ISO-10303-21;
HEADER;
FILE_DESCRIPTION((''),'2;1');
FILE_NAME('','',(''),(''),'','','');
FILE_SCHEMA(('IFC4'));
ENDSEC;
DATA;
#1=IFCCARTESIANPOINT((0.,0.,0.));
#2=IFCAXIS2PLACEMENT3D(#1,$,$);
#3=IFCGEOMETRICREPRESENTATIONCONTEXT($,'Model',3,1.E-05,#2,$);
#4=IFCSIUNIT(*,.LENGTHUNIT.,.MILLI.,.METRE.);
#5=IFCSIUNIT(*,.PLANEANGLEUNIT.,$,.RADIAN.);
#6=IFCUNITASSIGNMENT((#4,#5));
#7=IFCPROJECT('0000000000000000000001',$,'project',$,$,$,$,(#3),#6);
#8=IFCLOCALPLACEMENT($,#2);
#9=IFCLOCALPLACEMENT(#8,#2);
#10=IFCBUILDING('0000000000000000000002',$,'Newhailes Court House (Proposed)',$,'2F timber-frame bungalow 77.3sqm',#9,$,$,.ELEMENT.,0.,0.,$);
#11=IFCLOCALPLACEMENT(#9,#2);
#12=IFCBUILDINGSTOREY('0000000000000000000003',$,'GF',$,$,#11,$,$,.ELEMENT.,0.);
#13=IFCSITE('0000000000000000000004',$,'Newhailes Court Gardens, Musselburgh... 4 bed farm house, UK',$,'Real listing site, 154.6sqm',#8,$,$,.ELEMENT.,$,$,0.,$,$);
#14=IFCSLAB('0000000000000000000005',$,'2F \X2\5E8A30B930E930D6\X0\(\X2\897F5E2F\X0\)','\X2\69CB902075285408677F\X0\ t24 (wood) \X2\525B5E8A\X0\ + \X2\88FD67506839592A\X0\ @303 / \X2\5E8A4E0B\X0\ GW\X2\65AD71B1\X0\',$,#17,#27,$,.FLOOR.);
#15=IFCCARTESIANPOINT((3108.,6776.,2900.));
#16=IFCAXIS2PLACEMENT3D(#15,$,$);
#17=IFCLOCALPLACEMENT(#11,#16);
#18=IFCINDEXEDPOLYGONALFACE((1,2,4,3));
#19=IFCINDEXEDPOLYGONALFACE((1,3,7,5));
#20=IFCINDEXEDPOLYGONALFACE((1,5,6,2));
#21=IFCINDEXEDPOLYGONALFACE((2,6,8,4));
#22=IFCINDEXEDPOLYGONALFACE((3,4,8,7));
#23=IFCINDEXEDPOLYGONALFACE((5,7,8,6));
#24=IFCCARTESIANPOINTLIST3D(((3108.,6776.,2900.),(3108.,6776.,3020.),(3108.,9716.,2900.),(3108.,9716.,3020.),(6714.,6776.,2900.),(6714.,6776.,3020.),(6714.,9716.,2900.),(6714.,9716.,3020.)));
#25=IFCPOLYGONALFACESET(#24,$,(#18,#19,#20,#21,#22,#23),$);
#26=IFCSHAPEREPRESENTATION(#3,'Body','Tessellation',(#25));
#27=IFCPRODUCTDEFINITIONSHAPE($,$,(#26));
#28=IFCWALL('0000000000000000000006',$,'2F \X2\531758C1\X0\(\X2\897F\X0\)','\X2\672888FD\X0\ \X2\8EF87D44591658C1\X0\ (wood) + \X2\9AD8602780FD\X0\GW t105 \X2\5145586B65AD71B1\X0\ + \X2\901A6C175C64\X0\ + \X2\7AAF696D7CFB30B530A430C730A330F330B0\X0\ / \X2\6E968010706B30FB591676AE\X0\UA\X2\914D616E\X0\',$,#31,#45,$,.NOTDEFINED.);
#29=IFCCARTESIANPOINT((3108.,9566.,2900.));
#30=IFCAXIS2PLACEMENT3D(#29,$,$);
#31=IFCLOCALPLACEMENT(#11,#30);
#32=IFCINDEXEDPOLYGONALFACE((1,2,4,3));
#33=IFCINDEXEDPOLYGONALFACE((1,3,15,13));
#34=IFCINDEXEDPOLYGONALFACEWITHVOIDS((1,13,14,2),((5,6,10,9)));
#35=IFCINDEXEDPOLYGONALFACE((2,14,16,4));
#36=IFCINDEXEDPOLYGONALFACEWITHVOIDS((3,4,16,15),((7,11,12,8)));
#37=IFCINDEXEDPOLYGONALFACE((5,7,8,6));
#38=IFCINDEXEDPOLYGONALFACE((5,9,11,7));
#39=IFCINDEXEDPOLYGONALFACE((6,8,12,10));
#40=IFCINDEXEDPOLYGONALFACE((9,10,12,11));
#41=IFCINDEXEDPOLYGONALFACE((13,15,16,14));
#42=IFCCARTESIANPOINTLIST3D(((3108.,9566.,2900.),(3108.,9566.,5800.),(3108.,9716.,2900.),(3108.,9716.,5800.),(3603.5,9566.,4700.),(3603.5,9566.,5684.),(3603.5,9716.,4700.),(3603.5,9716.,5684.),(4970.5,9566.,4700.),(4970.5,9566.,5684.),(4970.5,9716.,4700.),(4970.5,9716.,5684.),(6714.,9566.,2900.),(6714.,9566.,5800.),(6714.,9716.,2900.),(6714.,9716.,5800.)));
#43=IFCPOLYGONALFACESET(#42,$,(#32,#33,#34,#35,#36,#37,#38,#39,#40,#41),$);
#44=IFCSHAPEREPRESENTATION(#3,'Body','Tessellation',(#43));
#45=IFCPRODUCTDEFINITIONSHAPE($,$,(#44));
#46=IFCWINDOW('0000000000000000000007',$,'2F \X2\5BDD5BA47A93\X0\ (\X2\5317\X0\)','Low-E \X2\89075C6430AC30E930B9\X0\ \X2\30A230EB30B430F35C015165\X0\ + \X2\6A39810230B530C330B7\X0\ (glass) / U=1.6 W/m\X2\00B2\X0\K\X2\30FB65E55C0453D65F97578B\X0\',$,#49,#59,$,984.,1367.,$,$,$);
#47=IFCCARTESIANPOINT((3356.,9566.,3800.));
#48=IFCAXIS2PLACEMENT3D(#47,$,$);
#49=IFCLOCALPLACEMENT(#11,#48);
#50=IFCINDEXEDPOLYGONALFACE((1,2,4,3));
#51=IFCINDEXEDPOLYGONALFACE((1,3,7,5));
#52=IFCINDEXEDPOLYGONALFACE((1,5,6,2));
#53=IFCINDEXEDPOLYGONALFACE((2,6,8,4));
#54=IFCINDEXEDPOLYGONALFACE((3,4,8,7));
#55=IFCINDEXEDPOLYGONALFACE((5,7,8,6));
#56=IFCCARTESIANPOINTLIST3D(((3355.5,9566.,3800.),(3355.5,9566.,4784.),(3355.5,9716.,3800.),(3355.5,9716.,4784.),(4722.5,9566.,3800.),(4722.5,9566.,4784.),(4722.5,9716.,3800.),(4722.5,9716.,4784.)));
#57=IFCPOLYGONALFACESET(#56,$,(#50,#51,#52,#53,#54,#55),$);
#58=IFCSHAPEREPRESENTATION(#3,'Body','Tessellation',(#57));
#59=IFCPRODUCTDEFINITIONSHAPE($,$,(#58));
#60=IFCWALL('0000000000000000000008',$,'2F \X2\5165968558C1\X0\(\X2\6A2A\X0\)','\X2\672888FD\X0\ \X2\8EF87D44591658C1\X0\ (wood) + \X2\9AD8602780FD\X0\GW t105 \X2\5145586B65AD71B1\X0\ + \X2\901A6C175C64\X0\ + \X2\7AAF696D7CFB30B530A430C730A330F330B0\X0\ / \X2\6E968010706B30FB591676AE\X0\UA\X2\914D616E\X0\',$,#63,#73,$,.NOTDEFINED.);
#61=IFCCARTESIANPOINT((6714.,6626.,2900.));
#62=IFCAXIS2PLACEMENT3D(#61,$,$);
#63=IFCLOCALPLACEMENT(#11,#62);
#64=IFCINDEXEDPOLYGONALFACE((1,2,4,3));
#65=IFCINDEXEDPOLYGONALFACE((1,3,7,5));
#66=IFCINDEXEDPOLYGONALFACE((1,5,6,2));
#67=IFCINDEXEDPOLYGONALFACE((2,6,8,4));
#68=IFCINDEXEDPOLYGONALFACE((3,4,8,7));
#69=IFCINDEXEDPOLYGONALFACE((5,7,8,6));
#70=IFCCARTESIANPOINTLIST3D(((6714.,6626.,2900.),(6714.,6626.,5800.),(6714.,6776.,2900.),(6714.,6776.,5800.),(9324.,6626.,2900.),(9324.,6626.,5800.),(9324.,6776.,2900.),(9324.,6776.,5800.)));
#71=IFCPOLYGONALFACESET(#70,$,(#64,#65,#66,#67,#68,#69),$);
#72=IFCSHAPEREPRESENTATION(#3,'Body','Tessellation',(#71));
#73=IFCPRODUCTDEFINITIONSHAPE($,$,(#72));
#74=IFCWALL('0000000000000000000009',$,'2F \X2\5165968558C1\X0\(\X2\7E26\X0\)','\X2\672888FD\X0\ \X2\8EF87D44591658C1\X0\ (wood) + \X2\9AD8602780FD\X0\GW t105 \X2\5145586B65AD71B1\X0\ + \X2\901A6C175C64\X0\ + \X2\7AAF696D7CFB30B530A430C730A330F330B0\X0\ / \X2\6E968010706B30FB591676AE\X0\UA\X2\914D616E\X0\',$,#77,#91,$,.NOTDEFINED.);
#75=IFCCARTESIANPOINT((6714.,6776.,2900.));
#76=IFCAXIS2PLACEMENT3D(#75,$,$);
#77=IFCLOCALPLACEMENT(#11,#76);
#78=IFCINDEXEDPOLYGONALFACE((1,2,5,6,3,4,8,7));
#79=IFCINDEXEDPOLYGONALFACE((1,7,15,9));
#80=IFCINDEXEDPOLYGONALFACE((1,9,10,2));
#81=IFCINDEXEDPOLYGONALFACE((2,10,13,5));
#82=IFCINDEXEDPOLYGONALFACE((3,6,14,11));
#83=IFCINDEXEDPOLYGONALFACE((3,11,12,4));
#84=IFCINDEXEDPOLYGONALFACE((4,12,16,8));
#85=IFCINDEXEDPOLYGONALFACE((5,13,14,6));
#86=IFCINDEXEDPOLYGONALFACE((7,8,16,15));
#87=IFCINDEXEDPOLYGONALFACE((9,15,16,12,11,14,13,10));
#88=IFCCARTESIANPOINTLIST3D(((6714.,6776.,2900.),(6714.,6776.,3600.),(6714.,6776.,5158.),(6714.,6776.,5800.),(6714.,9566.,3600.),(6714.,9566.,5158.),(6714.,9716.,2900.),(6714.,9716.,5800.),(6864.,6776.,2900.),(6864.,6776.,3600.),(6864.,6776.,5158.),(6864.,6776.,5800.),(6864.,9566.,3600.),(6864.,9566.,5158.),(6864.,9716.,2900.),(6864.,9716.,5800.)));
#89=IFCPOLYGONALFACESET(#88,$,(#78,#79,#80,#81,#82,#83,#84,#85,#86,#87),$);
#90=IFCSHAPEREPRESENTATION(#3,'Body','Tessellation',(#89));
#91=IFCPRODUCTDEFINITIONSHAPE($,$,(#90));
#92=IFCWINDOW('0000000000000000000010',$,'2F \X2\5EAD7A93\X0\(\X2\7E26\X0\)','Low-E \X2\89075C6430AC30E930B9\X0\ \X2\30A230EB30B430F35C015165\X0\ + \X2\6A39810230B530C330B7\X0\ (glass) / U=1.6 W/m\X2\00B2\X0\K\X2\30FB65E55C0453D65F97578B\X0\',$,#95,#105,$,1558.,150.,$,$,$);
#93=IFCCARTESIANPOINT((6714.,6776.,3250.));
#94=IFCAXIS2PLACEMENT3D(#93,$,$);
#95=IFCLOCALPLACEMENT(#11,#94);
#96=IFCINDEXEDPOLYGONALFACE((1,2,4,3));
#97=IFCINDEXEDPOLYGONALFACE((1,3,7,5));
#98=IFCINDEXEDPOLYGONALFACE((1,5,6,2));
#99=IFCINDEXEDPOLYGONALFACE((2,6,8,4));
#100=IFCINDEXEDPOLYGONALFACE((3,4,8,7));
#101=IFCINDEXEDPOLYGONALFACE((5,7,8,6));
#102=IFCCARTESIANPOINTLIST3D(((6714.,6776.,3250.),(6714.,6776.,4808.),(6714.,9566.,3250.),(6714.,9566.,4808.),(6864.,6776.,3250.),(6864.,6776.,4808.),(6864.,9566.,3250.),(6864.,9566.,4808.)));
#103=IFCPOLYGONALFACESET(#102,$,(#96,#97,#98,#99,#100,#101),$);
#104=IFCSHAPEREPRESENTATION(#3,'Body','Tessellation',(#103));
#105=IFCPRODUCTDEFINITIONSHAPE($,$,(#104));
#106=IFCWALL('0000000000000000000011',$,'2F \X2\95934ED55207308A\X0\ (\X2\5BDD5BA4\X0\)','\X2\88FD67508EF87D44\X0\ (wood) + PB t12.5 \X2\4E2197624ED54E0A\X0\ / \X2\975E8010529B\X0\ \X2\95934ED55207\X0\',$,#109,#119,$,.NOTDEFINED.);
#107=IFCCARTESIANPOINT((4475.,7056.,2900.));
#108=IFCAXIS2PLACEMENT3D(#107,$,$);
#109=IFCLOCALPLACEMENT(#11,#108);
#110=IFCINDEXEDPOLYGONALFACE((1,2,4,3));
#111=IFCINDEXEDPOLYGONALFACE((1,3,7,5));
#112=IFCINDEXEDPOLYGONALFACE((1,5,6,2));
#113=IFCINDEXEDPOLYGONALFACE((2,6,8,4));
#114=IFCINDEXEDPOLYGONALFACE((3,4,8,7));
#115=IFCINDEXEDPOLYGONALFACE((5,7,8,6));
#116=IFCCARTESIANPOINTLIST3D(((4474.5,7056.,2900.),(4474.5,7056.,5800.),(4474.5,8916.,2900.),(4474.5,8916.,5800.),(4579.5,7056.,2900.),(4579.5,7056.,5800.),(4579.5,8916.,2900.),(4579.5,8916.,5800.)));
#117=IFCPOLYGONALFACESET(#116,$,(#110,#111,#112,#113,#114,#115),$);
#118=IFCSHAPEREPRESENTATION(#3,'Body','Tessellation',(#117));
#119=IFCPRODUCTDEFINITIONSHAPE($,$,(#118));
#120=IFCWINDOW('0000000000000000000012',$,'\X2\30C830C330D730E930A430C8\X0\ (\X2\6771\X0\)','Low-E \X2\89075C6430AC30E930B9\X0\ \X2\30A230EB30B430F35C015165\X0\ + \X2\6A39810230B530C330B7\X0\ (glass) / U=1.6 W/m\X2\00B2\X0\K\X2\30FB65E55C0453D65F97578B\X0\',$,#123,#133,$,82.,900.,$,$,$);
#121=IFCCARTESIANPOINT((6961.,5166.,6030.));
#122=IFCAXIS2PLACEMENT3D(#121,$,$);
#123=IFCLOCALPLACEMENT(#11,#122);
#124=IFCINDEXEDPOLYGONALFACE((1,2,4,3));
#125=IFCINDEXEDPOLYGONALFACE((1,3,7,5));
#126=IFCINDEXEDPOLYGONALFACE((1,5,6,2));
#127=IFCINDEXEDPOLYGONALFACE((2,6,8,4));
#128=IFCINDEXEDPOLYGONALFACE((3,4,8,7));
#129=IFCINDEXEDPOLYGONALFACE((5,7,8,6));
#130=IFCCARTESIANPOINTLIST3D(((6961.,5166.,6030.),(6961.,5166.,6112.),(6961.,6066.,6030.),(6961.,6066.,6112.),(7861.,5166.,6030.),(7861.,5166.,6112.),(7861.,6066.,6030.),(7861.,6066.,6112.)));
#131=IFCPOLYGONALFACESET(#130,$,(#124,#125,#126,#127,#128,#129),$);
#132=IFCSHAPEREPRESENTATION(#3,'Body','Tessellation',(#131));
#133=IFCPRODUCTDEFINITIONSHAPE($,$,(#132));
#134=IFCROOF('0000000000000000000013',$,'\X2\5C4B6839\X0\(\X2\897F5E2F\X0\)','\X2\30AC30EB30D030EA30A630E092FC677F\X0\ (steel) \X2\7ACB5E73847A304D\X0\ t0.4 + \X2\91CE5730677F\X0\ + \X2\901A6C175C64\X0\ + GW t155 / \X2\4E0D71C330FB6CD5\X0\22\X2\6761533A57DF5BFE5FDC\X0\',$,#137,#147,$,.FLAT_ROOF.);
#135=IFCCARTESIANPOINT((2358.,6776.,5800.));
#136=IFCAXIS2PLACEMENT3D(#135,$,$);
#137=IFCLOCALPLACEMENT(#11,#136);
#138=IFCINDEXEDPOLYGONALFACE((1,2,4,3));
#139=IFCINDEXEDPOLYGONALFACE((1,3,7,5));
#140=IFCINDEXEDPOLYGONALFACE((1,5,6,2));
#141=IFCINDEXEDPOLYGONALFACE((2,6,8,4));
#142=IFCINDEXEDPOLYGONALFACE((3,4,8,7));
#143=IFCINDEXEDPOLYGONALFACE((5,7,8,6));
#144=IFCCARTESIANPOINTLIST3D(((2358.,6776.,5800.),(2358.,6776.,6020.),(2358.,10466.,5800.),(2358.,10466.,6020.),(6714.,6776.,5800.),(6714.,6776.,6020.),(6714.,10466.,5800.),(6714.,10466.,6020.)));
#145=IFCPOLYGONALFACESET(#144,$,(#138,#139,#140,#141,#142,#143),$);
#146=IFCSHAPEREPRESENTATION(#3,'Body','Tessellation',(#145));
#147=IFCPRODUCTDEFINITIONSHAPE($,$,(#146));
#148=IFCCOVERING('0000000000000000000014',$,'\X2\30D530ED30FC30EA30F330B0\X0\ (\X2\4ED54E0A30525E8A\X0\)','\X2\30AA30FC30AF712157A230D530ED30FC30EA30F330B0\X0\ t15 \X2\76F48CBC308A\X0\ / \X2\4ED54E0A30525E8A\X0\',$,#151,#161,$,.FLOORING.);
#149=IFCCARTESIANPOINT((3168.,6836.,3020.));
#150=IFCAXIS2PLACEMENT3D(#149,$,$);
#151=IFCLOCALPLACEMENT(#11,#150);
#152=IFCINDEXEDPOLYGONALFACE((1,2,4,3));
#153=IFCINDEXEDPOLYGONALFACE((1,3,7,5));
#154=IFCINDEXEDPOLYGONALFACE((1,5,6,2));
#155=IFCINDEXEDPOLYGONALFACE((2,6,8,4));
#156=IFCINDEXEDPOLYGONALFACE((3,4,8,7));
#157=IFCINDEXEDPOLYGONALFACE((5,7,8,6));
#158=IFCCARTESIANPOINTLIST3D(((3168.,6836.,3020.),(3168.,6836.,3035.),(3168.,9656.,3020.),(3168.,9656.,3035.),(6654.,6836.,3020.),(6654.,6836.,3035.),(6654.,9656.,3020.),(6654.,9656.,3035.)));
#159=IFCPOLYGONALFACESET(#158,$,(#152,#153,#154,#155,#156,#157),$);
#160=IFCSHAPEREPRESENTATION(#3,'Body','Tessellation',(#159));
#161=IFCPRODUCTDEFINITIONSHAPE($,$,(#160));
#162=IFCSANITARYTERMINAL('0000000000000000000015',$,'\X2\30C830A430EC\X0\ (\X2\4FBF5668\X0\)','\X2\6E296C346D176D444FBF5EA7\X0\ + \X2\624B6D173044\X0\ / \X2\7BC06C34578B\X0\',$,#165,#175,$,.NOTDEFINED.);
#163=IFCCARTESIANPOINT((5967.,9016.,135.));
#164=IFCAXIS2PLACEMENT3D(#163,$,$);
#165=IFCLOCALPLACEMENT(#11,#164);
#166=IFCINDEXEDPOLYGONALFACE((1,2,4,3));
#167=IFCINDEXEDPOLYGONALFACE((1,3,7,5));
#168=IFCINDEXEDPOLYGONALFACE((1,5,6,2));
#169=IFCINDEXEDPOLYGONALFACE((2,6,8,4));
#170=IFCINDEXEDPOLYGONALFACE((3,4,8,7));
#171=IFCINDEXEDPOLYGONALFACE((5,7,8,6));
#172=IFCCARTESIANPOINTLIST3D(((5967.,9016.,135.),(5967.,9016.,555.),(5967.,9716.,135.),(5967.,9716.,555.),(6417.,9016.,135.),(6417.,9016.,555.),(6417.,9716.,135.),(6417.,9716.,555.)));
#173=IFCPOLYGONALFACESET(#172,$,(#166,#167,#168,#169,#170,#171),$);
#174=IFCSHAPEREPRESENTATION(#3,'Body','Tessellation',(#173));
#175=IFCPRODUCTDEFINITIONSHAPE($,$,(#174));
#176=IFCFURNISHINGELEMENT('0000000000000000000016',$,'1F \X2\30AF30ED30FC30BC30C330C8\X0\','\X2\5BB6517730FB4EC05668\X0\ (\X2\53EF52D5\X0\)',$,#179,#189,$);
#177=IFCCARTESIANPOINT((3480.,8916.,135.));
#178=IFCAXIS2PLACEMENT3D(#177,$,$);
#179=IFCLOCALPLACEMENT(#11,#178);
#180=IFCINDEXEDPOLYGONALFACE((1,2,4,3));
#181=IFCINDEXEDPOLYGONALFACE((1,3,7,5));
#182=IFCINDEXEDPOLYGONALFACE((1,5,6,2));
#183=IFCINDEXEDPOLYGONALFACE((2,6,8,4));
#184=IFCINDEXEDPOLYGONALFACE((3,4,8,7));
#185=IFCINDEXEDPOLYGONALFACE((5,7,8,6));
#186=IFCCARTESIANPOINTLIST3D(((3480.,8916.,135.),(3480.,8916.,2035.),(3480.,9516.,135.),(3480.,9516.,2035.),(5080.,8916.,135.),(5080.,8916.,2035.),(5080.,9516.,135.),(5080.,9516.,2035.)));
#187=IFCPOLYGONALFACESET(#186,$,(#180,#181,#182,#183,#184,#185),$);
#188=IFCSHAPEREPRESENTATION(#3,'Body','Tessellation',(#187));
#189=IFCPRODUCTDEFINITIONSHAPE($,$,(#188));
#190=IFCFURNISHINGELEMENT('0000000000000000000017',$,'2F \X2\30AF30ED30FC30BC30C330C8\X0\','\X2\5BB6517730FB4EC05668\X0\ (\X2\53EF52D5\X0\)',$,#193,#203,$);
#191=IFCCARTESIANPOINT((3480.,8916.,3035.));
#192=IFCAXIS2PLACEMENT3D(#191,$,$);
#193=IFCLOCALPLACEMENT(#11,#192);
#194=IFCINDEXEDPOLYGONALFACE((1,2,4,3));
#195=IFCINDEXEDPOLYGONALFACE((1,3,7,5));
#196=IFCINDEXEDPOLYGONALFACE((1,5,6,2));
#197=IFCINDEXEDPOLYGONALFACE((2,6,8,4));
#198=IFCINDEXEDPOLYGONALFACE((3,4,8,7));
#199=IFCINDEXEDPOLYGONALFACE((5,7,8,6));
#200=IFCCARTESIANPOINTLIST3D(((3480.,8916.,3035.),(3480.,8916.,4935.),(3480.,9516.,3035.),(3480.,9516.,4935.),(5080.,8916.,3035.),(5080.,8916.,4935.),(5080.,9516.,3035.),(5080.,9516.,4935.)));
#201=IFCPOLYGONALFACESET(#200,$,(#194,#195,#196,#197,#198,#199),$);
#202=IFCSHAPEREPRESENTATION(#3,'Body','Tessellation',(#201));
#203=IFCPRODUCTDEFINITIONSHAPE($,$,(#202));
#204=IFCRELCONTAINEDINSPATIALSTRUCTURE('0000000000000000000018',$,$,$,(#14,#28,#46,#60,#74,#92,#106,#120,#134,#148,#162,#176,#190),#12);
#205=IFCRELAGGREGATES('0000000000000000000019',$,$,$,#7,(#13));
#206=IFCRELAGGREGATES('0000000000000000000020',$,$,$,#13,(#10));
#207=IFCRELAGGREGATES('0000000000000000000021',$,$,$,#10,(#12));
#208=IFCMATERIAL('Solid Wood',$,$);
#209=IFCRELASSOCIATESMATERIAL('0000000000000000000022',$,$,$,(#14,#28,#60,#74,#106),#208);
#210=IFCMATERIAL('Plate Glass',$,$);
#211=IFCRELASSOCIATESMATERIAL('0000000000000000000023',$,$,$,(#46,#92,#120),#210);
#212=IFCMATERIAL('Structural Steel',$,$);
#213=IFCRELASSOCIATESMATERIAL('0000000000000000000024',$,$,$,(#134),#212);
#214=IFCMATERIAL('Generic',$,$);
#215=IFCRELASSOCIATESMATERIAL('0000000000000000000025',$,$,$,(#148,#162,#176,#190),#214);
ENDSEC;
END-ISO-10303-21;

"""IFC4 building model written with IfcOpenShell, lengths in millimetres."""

from ifc_helpers import new_model, si_unit, frame, frame_2d, origin, place, context, project, spatial, rectangle, extrude, material, element, fill, save


model = new_model("IFC4")

# Units and contexts
model_context = context("Model", 3, precision=1e-05, world=origin())
ifc_project = project(units=[si_unit("LENGTHUNIT", "METRE", prefix="MILLI"), si_unit("PLANEANGLEUNIT", "RADIAN")], contexts=[model_context])

# Site, building, storey
site_placement = place(None, origin())
site = spatial("IfcSite", under=ifc_project, at=site_placement, Name="Newhailes Court Gardens, Musselburgh... 4 bed farm house, UK", ObjectType="Real listing site, 154.6sqm", CompositionType="ELEMENT", RefElevation=0.0)
building_placement = place(site_placement, origin())
building = spatial("IfcBuilding", under=site, at=building_placement, Name="Newhailes Court House (Proposed)", ObjectType="2F timber-frame bungalow 77.3sqm", CompositionType="ELEMENT", ElevationOfRefHeight=0.0, ElevationOfTerrain=0.0)
storey_placement = place(building_placement, origin())
storey = spatial("IfcBuildingStorey", under=building, at=storey_placement, Name="GF", CompositionType="ELEMENT", Elevation=0.0)

# Slab
ifc_material_1 = material(Name="Solid Wood")
slab_placement = place(storey_placement, frame((3108.0, 6776.0, 2900.0)))
element("IfcSlab", 1, at=slab_placement, inside=storey, material=ifc_material_1, Name="2F 床スラブ(西帯)", Description="構造用合板 t24 (wood) 剛床 + 製材根太 @303 / 床下 GW断熱", PredefinedType="FLOOR", context=model_context, shape_type="SweptSolid", body=[
    extrude(rectangle(XDim=3606.0, YDim=2940.0, at=frame_2d((1803.0, 1470.0))), frame((3108.0, 6776.0, 2900.0)), (0.0, 0.0, 1.0), 120.0),
])

# Wall, opening, window
wall_1_placement = place(storey_placement, frame((3108.0, 9566.0, 2900.0)))
wall_1 = element("IfcWall", 2, at=wall_1_placement, inside=storey, material=ifc_material_1, Name="2F 北壁(西)", Description="木製 軸組外壁 (wood) + 高性能GW t105 充填断熱 + 通気層 + 窯業系サイディング / 準耐火・外皮UA配慮", PredefinedType="NOTDEFINED", context=model_context, shape_type="SweptSolid", body=[
    extrude(rectangle(XDim=3606.0, YDim=150.0, at=frame_2d((1803.0, 75.0))), frame((3108.0, 9566.0, 2900.0)), (0.0, 0.0, 1.0), 2900.0),
])
opening_1_placement = place(storey_placement, frame((3356.0, 9566.0, 3800.0)))
opening_1 = element("IfcOpeningElement", 3, at=opening_1_placement, cuts=wall_1, PredefinedType="NOTDEFINED", context=model_context, shape_type="SweptSolid", body=[
    extrude(rectangle(XDim=1367.0, YDim=150.0, at=frame_2d((683.0, 75.0))), frame((3356.0, 9566.0, 3800.0)), (0.0, 0.0, 1.0), 984.0),
])
ifc_material_2 = material(Name="Plate Glass")
window_1_placement = place(storey_placement, frame((3356.0, 9566.0, 3800.0)))
window_1 = element("IfcWindow", 4, at=window_1_placement, inside=storey, material=ifc_material_2, Name="2F 寝室窓 (北)", Description="Low-E 複層ガラス アルゴン封入 + 樹脂サッシ (glass) / U=1.6 W/m²K・日射取得型", OverallHeight=984.0, OverallWidth=1367.0, context=model_context, shape_type="SweptSolid", body=[
    extrude(rectangle(XDim=1367.0, YDim=150.0, at=frame_2d((683.0, 75.0))), frame((3356.0, 9566.0, 3800.0)), (0.0, 0.0, 1.0), 984.0),
])
fill(opening_1, window_1)

# Wall
wall_2_placement = place(storey_placement, frame((6714.0, 6626.0, 2900.0)))
element("IfcWall", 5, at=wall_2_placement, inside=storey, material=ifc_material_1, Name="2F 入隅壁(横)", Description="木製 軸組外壁 (wood) + 高性能GW t105 充填断熱 + 通気層 + 窯業系サイディング / 準耐火・外皮UA配慮", PredefinedType="NOTDEFINED", context=model_context, shape_type="SweptSolid", body=[
    extrude(rectangle(XDim=2610.0, YDim=150.0, at=frame_2d((1305.0, 75.0))), frame((6714.0, 6626.0, 2900.0)), (0.0, 0.0, 1.0), 2900.0),
])

# Wall, opening, window
wall_3_placement = place(storey_placement, frame((6714.0, 6776.0, 2900.0)))
wall_3 = element("IfcWall", 6, at=wall_3_placement, inside=storey, material=ifc_material_1, Name="2F 入隅壁(縦)", Description="木製 軸組外壁 (wood) + 高性能GW t105 充填断熱 + 通気層 + 窯業系サイディング / 準耐火・外皮UA配慮", PredefinedType="NOTDEFINED", context=model_context, shape_type="SweptSolid", body=[
    extrude(rectangle(XDim=150.0, YDim=2940.0, at=frame_2d((75.0, 1470.0))), frame((6714.0, 6776.0, 2900.0)), (0.0, 0.0, 1.0), 2900.0),
])
opening_2_placement = place(storey_placement, frame((6714.0, 6776.0, 3250.0)))
opening_2 = element("IfcOpeningElement", 7, at=opening_2_placement, cuts=wall_3, PredefinedType="NOTDEFINED", context=model_context, shape_type="SweptSolid", body=[
    extrude(rectangle(XDim=150.0, YDim=2790.0, at=frame_2d((75.0, 1395.0))), frame((6714.0, 6776.0, 3250.0)), (0.0, 0.0, 1.0), 1558.0),
])
window_2_placement = place(storey_placement, frame((6714.0, 6776.0, 3250.0)))
window_2 = element("IfcWindow", 8, at=window_2_placement, inside=storey, material=ifc_material_2, Name="2F 庭窓(縦)", Description="Low-E 複層ガラス アルゴン封入 + 樹脂サッシ (glass) / U=1.6 W/m²K・日射取得型", OverallHeight=1558.0, OverallWidth=150.0, context=model_context, shape_type="SweptSolid", body=[
    extrude(rectangle(XDim=150.0, YDim=2790.0, at=frame_2d((75.0, 1395.0))), frame((6714.0, 6776.0, 3250.0)), (0.0, 0.0, 1.0), 1558.0),
])
fill(opening_2, window_2)

# Wall
wall_4_placement = place(storey_placement, frame((4475.0, 7056.0, 2900.0)))
element("IfcWall", 9, at=wall_4_placement, inside=storey, material=ifc_material_1, Name="2F 間仕切り (寝室)", Description="製材軸組 (wood) + PB t12.5 両面仕上 / 非耐力 間仕切", PredefinedType="NOTDEFINED", context=model_context, shape_type="SweptSolid", body=[
    extrude(rectangle(XDim=105.0, YDim=1860.0, at=frame_2d((52.0, 930.0))), frame((4475.0, 7056.0, 2900.0)), (0.0, 0.0, 1.0), 2900.0),
])

# Window
window_3_placement = place(storey_placement, frame((6961.0, 5166.0, 6030.0)))
element("IfcWindow", 10, at=window_3_placement, inside=storey, material=ifc_material_2, Name="トップライト (東)", Description="Low-E 複層ガラス アルゴン封入 + 樹脂サッシ (glass) / U=1.6 W/m²K・日射取得型", OverallHeight=82.0, OverallWidth=900.0, context=model_context, shape_type="SweptSolid", body=[
    extrude(rectangle(XDim=900.0, YDim=900.0, at=frame_2d((450.0, 450.0))), frame((6961.0, 5166.0, 6030.0)), (0.0, 0.0, 1.0), 82.0),
])

# Roof
ifc_material_3 = material(Name="Structural Steel")
for number, where, name in (
    (11, (2358.0, 6776.0, 5800.0), "屋根(西帯)"),
):
    element("IfcRoof", number, at=place(storey_placement, frame(where)), inside=storey, material=ifc_material_3, Name=name, Description="ガルバリウム鋼板 (steel) 立平葺き t0.4 + 野地板 + 通気層 + GW t155 / 不燃・法22条区域対応", PredefinedType="FLAT_ROOF", context=model_context, shape_type="SweptSolid", body=[
        extrude(rectangle(XDim=4356.0, YDim=3690.0, at=frame_2d((2178.0, 1845.0))), frame((2358.0, 6776.0, 5800.0)), (0.0, 0.0, 1.0), 220.0),
    ])

# Covering
ifc_material_4 = material(Name="Generic")
covering_placement = place(storey_placement, frame((3168.0, 6836.0, 3020.0)))
element("IfcCovering", 12, at=covering_placement, inside=storey, material=ifc_material_4, Name="フローリング (仕上げ床)", Description="オーク無垢フローリング t15 直貼り / 仕上げ床", PredefinedType="FLOORING", context=model_context, shape_type="SweptSolid", body=[
    extrude(rectangle(XDim=3486.0, YDim=2820.0, at=frame_2d((1743.0, 1410.0))), frame((3168.0, 6836.0, 3020.0)), (0.0, 0.0, 1.0), 15.0),
])

# Sanitary terminal
sanitary_terminal_placement = place(storey_placement, frame((5967.0, 9016.0, 135.0)))
element("IfcSanitaryTerminal", 13, at=sanitary_terminal_placement, inside=storey, material=ifc_material_4, Name="トイレ (便器)", Description="温水洗浄便座 + 手洗い / 節水型", PredefinedType="NOTDEFINED", context=model_context, shape_type="SweptSolid", body=[
    extrude(rectangle(XDim=450.0, YDim=700.0, at=frame_2d((225.0, 350.0))), frame((5967.0, 9016.0, 135.0)), (0.0, 0.0, 1.0), 420.0),
])

# Furnishing elements
furnishing_1_placement = place(storey_placement, frame((3480.0, 8916.0, 135.0)))
element("IfcFurnishingElement", 14, at=furnishing_1_placement, inside=storey, material=ifc_material_4, Name="1F クローゼット", Description="家具・什器 (可動)", context=model_context, shape_type="SweptSolid", body=[
    extrude(rectangle(XDim=1600.0, YDim=600.0, at=frame_2d((800.0, 300.0))), frame((3480.0, 8916.0, 135.0)), (0.0, 0.0, 1.0), 1900.0),
])
furnishing_2_placement = place(storey_placement, frame((3480.0, 8916.0, 3035.0)))
element("IfcFurnishingElement", 15, at=furnishing_2_placement, inside=storey, material=ifc_material_4, Name="2F クローゼット", Description="家具・什器 (可動)", context=model_context, shape_type="SweptSolid", body=[
    extrude(rectangle(XDim=1600.0, YDim=600.0, at=frame_2d((800.0, 300.0))), frame((3480.0, 8916.0, 3035.0)), (0.0, 0.0, 1.0), 1900.0),
])

save(model, "model.ifc")
